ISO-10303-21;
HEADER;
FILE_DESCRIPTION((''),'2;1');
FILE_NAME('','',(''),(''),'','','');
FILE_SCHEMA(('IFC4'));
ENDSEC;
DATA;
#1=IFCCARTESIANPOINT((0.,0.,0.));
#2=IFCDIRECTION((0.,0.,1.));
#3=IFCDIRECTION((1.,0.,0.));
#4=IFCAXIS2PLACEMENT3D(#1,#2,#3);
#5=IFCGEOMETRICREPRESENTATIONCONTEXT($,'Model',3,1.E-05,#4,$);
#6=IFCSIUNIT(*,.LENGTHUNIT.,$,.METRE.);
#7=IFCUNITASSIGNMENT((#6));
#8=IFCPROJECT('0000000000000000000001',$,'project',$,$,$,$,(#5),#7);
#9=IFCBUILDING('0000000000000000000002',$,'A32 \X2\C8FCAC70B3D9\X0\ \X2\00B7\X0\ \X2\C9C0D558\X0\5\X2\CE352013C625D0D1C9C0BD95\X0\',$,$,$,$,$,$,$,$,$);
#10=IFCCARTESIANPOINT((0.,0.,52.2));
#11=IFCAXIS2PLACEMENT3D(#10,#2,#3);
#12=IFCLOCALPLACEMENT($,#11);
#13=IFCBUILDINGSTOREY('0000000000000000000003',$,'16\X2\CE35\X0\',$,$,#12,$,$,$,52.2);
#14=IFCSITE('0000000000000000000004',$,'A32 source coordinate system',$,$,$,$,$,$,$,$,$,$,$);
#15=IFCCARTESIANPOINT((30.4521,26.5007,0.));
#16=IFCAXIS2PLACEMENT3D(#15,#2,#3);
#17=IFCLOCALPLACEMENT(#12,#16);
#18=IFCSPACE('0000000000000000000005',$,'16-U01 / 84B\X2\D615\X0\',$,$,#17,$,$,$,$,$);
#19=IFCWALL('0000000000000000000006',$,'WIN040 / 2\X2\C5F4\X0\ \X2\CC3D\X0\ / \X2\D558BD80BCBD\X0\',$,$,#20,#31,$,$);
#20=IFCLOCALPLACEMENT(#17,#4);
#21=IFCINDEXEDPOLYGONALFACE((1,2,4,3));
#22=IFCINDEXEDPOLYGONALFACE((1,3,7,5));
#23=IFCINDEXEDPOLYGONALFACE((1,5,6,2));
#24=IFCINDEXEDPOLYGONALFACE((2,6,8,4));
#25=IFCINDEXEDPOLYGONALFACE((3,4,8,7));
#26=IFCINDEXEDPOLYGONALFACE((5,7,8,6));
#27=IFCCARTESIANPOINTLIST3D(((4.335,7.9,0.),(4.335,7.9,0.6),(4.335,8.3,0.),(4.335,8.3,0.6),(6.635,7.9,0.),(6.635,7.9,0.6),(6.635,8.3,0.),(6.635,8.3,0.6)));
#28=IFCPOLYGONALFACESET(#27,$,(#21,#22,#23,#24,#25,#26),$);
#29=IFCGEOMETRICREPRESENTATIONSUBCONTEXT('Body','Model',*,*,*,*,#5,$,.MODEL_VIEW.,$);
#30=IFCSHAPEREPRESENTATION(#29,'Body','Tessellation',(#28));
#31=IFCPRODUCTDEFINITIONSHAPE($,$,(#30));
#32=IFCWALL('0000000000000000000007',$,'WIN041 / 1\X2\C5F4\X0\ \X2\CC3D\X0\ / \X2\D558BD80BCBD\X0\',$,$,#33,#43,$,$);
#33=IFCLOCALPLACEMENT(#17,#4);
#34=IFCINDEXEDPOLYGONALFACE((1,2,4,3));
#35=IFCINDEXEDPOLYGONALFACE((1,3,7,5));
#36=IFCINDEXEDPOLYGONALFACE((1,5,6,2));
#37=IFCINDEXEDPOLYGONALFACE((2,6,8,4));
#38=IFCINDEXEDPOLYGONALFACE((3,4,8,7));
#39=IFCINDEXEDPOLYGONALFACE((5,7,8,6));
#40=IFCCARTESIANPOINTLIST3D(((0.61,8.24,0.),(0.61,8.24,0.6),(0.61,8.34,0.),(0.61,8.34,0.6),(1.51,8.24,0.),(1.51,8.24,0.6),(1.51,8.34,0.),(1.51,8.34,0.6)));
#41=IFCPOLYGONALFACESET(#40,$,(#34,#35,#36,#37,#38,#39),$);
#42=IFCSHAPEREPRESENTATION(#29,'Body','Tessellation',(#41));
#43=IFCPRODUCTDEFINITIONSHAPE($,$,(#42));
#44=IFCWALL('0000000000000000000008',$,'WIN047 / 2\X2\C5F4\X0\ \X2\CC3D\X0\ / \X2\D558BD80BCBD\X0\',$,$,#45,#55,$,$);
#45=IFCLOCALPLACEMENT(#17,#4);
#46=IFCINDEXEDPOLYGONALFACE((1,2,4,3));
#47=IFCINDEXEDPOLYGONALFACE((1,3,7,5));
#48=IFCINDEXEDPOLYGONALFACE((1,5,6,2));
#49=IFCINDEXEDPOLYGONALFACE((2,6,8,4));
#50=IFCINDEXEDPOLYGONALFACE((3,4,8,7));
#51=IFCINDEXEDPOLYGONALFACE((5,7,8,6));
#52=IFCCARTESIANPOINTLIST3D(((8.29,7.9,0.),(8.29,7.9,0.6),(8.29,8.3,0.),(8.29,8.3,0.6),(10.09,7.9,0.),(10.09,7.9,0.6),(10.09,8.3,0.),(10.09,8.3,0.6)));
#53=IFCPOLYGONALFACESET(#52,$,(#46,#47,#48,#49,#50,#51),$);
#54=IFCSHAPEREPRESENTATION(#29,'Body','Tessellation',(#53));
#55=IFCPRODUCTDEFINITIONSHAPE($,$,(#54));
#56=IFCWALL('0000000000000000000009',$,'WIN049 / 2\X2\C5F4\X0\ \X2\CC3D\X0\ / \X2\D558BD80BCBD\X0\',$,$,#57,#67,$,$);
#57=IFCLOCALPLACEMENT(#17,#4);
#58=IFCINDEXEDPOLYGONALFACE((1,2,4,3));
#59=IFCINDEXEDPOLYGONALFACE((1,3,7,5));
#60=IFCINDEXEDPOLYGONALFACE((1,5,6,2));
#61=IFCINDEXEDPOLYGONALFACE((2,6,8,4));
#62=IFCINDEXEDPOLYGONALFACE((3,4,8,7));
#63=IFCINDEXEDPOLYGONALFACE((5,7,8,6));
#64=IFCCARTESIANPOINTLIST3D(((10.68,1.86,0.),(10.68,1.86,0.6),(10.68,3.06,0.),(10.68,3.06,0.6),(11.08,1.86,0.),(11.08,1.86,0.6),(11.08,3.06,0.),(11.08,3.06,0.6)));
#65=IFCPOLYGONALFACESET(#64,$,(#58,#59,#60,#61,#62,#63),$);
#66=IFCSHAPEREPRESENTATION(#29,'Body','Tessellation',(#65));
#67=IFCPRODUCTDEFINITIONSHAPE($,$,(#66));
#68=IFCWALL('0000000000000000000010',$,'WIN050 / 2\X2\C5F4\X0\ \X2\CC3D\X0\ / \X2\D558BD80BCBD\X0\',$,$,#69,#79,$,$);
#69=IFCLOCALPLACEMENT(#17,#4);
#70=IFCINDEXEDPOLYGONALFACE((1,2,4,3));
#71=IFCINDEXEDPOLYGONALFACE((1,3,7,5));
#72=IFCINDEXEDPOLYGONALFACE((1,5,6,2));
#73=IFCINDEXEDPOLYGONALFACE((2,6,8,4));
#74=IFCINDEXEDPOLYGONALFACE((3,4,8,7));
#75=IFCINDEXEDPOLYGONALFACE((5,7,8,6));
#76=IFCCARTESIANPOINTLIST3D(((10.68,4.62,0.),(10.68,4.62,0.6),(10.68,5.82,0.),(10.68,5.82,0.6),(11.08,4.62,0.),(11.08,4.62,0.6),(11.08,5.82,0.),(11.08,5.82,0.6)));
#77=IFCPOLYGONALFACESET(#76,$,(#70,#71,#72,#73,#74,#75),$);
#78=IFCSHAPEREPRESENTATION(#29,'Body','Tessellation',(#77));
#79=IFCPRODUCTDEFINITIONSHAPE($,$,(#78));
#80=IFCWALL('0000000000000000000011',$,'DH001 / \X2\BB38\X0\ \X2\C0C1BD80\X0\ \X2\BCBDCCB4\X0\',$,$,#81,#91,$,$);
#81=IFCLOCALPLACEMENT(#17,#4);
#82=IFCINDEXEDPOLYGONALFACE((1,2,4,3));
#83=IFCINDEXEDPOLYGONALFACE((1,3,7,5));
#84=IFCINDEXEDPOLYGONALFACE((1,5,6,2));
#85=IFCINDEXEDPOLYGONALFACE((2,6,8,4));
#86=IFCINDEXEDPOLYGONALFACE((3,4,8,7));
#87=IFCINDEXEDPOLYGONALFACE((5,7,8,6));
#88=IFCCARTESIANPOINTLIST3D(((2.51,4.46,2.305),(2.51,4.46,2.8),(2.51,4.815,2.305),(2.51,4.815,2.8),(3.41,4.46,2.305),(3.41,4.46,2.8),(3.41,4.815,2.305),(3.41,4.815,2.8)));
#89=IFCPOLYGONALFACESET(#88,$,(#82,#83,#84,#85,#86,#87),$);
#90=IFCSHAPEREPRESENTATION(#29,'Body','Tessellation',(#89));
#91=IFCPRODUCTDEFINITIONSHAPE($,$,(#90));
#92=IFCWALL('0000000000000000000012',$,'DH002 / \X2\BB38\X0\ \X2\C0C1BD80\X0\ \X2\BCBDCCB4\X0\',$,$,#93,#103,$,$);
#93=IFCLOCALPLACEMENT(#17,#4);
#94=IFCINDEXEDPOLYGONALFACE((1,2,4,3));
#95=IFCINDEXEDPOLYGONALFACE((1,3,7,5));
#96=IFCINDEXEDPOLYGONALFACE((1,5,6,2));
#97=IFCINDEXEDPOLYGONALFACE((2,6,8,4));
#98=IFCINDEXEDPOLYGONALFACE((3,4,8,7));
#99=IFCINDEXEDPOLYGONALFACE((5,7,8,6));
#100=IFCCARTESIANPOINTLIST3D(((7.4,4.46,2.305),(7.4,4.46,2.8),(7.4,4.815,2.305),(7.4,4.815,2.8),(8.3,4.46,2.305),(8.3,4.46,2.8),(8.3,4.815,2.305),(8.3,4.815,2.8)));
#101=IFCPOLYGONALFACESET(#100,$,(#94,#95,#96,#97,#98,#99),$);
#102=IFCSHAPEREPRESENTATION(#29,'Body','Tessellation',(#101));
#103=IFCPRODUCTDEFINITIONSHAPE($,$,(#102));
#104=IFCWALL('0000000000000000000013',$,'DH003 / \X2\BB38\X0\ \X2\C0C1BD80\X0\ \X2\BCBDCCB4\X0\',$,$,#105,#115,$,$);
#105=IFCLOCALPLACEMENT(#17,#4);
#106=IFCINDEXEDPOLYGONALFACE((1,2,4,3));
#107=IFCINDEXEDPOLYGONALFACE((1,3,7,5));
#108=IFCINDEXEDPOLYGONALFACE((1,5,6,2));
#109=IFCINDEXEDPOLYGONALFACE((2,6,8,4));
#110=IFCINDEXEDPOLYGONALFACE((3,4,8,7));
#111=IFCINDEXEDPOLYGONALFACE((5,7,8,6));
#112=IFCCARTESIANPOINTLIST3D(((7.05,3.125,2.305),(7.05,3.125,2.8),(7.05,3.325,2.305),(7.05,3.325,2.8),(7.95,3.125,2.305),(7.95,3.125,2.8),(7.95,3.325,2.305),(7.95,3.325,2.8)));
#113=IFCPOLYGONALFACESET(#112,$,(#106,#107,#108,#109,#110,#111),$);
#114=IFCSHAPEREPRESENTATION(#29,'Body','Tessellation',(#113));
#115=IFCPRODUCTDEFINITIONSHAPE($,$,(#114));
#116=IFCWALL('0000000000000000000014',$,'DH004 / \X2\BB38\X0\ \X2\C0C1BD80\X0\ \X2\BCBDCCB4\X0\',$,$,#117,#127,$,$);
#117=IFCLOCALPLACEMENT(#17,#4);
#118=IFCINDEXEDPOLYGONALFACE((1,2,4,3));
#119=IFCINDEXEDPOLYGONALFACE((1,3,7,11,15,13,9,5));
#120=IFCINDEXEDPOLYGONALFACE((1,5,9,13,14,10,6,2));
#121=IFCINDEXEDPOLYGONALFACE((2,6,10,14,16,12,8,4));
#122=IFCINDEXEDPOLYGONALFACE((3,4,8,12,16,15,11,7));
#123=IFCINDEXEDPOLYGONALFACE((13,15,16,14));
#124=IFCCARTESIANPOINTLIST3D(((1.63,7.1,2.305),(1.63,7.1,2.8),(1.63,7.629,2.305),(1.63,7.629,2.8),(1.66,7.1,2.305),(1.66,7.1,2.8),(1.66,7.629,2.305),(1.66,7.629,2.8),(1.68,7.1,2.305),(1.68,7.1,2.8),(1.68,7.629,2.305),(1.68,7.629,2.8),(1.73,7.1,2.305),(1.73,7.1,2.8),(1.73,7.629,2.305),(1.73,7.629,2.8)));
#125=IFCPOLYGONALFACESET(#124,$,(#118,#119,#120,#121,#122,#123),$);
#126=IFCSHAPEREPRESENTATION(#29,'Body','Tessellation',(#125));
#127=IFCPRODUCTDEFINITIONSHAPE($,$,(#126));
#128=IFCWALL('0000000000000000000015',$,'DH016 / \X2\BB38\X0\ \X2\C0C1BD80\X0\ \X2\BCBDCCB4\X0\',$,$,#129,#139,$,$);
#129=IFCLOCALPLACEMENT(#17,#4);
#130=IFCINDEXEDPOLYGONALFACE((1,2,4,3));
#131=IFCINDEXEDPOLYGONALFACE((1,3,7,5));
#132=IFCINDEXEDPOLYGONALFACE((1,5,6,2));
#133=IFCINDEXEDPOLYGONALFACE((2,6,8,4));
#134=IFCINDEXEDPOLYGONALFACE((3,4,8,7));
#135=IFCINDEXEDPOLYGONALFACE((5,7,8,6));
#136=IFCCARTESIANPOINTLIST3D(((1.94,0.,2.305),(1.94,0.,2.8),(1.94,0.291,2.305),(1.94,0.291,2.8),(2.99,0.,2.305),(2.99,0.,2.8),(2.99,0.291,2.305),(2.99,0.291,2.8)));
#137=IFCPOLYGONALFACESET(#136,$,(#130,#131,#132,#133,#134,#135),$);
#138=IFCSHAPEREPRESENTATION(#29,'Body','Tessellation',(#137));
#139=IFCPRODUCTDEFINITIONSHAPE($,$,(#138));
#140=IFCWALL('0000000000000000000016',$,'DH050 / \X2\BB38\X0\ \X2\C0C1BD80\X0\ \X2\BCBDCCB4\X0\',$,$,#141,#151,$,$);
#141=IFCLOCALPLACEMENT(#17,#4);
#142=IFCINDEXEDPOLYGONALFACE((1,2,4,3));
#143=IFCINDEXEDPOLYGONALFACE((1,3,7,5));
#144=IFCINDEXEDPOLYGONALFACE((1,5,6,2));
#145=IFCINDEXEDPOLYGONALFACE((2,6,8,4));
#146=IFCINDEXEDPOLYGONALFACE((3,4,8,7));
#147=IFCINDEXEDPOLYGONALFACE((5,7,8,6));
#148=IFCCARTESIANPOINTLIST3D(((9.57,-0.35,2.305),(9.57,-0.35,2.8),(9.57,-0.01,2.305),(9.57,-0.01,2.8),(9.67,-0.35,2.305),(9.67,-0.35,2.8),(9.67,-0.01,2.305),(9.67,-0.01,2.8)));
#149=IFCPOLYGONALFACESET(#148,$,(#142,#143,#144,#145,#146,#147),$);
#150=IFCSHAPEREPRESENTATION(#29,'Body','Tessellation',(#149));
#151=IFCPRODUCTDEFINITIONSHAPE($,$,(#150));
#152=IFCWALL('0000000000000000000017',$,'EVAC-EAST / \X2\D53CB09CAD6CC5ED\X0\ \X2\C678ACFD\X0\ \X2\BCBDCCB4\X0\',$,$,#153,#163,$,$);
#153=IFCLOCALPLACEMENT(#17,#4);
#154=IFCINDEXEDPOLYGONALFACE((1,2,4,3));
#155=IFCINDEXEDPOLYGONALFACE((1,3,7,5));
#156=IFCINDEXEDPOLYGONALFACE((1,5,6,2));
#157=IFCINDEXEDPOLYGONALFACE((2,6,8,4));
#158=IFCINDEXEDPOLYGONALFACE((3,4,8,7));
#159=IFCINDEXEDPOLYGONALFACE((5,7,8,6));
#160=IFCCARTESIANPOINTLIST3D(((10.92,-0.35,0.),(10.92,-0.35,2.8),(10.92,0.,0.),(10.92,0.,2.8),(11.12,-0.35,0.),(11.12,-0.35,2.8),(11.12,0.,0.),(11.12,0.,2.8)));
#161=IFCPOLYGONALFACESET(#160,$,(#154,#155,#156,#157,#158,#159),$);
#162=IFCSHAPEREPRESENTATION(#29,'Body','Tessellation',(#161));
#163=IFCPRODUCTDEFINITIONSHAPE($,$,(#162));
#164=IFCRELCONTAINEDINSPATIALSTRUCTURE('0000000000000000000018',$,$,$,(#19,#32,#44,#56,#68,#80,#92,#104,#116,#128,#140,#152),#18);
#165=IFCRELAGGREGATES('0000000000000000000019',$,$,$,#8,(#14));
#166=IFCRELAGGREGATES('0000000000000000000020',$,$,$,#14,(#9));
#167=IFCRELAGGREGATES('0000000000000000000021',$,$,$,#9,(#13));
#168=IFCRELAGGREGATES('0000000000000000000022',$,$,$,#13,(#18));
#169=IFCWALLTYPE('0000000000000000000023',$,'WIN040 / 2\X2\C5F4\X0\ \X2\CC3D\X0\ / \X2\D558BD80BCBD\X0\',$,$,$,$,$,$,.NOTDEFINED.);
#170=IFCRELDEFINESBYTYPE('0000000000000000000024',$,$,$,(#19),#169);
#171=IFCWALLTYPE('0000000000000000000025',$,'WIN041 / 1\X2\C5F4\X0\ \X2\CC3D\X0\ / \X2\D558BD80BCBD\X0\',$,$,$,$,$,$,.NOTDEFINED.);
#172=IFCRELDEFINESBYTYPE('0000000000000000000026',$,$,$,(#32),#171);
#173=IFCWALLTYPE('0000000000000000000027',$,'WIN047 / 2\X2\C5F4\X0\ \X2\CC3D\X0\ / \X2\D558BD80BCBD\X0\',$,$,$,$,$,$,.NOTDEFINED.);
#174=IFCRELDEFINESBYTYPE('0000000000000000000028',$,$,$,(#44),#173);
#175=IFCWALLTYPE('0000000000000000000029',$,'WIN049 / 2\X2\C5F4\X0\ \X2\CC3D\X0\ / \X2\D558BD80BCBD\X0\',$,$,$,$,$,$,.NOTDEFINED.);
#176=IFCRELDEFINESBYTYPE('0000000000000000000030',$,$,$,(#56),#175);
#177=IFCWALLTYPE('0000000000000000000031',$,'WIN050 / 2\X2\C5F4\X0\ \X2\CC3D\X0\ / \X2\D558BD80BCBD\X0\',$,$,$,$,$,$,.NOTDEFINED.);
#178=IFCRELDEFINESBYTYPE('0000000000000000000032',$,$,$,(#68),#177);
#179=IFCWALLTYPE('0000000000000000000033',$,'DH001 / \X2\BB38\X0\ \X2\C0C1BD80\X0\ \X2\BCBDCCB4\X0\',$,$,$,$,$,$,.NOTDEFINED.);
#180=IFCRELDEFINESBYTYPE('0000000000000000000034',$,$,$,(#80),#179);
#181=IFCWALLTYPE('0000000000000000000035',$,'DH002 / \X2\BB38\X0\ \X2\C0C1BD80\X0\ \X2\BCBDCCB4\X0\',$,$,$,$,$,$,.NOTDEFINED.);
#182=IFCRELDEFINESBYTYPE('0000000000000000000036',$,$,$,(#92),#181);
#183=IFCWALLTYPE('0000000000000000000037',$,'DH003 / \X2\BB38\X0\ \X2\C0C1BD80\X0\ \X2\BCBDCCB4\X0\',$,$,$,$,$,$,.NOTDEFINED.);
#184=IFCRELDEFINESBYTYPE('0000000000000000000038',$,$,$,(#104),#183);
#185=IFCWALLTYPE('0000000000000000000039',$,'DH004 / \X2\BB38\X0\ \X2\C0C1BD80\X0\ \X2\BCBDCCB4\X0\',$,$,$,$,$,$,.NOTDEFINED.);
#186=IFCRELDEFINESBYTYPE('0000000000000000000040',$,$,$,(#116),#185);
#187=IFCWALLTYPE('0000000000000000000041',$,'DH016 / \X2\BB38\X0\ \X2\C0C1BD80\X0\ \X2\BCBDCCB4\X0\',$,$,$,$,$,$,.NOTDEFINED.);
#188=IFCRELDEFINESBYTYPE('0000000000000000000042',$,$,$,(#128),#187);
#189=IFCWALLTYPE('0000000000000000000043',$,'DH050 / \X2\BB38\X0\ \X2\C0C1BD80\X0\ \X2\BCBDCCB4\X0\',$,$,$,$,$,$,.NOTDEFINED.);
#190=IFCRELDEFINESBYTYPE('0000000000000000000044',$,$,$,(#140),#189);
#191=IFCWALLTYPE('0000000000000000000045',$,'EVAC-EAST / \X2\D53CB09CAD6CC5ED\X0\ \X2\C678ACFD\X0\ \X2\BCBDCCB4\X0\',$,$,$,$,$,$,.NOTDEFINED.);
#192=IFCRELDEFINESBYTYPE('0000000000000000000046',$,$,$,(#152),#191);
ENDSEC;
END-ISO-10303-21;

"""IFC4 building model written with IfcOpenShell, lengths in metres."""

from ifc_helpers import new_model, si_unit, frame, origin, origin_with_axes, place, context, subcontext, project, spatial, polyline, outline, extrude, source, transform, mapped, type_object, type_shapes, element, save


model = new_model("IFC4")

# Units and contexts
model_context = context("Model", 3, precision=1e-05, world=origin_with_axes())
body_context = subcontext(model_context, "Body", "Model", "MODEL_VIEW")
ifc_project = project(units=[si_unit("LENGTHUNIT", "METRE")], contexts=[model_context])

# Site, building, storey, space
site = spatial("IfcSite", under=ifc_project, Name="A32 source coordinate system")
building = spatial("IfcBuilding", under=site, Name="A32 주거동 · 지하5층–옥탑지붕")
storey_placement = place(None, frame((0.0, 0.0, 52.2), z_axis=(0.0, 0.0, 1.0), x_axis=(1.0, 0.0, 0.0)))
storey = spatial("IfcBuildingStorey", under=building, at=storey_placement, Name="16층", Elevation=52.2)
space_placement = place(storey_placement, frame((30.4521, 26.5007, 0.0), z_axis=(0.0, 0.0, 1.0), x_axis=(1.0, 0.0, 0.0)))
space = spatial("IfcSpace", under=storey, at=space_placement, Name="16-U01 / 84B형")

# Walls
wall_type_1 = type_object("IfcWallType", Name="WIN040 / 2열 창 / 하부벽", PredefinedType="NOTDEFINED")
shared_shape_1 = source(origin(), body_context, "Body", "SweptSolid", [
    extrude(outline(polyline([(4.335, 8.3), (6.635, 8.3), (6.635, 7.9), (4.335, 7.9), (4.335, 8.3)])), origin(), (0.0, 0.0, 1.0), 0.6),
])
type_shapes(wall_type_1, [shared_shape_1])
wall_1_placement = place(space_placement, origin_with_axes())
element("IfcWall", 1, at=wall_1_placement, inside=space, type_object=wall_type_1, Name="WIN040 / 2열 창 / 하부벽", context=body_context, shape_type="MappedRepresentation", body=[
    mapped(shared_shape_1, transform((0.0, 0.0, 0.0), scale=1.0)),
])
wall_type_2 = type_object("IfcWallType", Name="WIN041 / 1열 창 / 하부벽", PredefinedType="NOTDEFINED")
shared_shape_2 = source(origin(), body_context, "Body", "SweptSolid", [
    extrude(outline(polyline([(0.61, 8.34), (1.51, 8.34), (1.51, 8.24), (0.61, 8.24), (0.61, 8.34)])), origin(), (0.0, 0.0, 1.0), 0.6),
])
type_shapes(wall_type_2, [shared_shape_2])
wall_2_placement = place(space_placement, origin_with_axes())
element("IfcWall", 2, at=wall_2_placement, inside=space, type_object=wall_type_2, Name="WIN041 / 1열 창 / 하부벽", context=body_context, shape_type="MappedRepresentation", body=[
    mapped(shared_shape_2, transform((0.0, 0.0, 0.0), scale=1.0)),
])
wall_type_3 = type_object("IfcWallType", Name="WIN047 / 2열 창 / 하부벽", PredefinedType="NOTDEFINED")
shared_shape_3 = source(origin(), body_context, "Body", "SweptSolid", [
    extrude(outline(polyline([(8.29, 8.3), (10.09, 8.3), (10.09, 7.9), (8.29, 7.9), (8.29, 8.3)])), origin(), (0.0, 0.0, 1.0), 0.6),
])
type_shapes(wall_type_3, [shared_shape_3])
wall_3_placement = place(space_placement, origin_with_axes())
element("IfcWall", 3, at=wall_3_placement, inside=space, type_object=wall_type_3, Name="WIN047 / 2열 창 / 하부벽", context=body_context, shape_type="MappedRepresentation", body=[
    mapped(shared_shape_3, transform((0.0, 0.0, 0.0), scale=1.0)),
])
wall_type_4 = type_object("IfcWallType", Name="WIN049 / 2열 창 / 하부벽", PredefinedType="NOTDEFINED")
shared_shape_4 = source(origin(), body_context, "Body", "SweptSolid", [
    extrude(outline(polyline([(10.68, 3.06), (11.08, 3.06), (11.08, 1.86), (10.68, 1.86), (10.68, 3.06)])), origin(), (0.0, 0.0, 1.0), 0.6),
])
type_shapes(wall_type_4, [shared_shape_4])
wall_4_placement = place(space_placement, origin_with_axes())
element("IfcWall", 4, at=wall_4_placement, inside=space, type_object=wall_type_4, Name="WIN049 / 2열 창 / 하부벽", context=body_context, shape_type="MappedRepresentation", body=[
    mapped(shared_shape_4, transform((0.0, 0.0, 0.0), scale=1.0)),
])
wall_type_5 = type_object("IfcWallType", Name="WIN050 / 2열 창 / 하부벽", PredefinedType="NOTDEFINED")
shared_shape_5 = source(origin(), body_context, "Body", "SweptSolid", [
    extrude(outline(polyline([(10.68, 5.82), (11.08, 5.82), (11.08, 4.62), (10.68, 4.62), (10.68, 5.82)])), origin(), (0.0, 0.0, 1.0), 0.6),
])
type_shapes(wall_type_5, [shared_shape_5])
wall_5_placement = place(space_placement, origin_with_axes())
element("IfcWall", 5, at=wall_5_placement, inside=space, type_object=wall_type_5, Name="WIN050 / 2열 창 / 하부벽", context=body_context, shape_type="MappedRepresentation", body=[
    mapped(shared_shape_5, transform((0.0, 0.0, 0.0), scale=1.0)),
])
wall_type_6 = type_object("IfcWallType", Name="DH001 / 문 상부 벽체", PredefinedType="NOTDEFINED")
shared_shape_6 = source(origin(), body_context, "Body", "SweptSolid", [
    extrude(outline(polyline([(3.41, 4.815), (3.41, 4.46), (2.51, 4.46), (2.51, 4.815), (3.41, 4.815)])), frame((0.0, 0.0, 2.305)), (0.0, 0.0, 1.0), 0.495),
])
type_shapes(wall_type_6, [shared_shape_6])
wall_6_placement = place(space_placement, origin_with_axes())
element("IfcWall", 6, at=wall_6_placement, inside=space, type_object=wall_type_6, Name="DH001 / 문 상부 벽체", context=body_context, shape_type="MappedRepresentation", body=[
    mapped(shared_shape_6, transform((0.0, 0.0, 0.0), scale=1.0)),
])
wall_type_7 = type_object("IfcWallType", Name="DH002 / 문 상부 벽체", PredefinedType="NOTDEFINED")
shared_shape_7 = source(origin(), body_context, "Body", "SweptSolid", [
    extrude(outline(polyline([(8.3, 4.815), (8.3, 4.46), (7.4, 4.46), (7.4, 4.815), (8.3, 4.815)])), frame((0.0, 0.0, 2.305)), (0.0, 0.0, 1.0), 0.495),
])
type_shapes(wall_type_7, [shared_shape_7])
wall_7_placement = place(space_placement, origin_with_axes())
element("IfcWall", 7, at=wall_7_placement, inside=space, type_object=wall_type_7, Name="DH002 / 문 상부 벽체", context=body_context, shape_type="MappedRepresentation", body=[
    mapped(shared_shape_7, transform((0.0, 0.0, 0.0), scale=1.0)),
])
wall_type_8 = type_object("IfcWallType", Name="DH003 / 문 상부 벽체", PredefinedType="NOTDEFINED")
shared_shape_8 = source(origin(), body_context, "Body", "SweptSolid", [
    extrude(outline(polyline([(7.95, 3.325), (7.95, 3.125), (7.05, 3.125), (7.05, 3.325), (7.95, 3.325)])), frame((0.0, 0.0, 2.305)), (0.0, 0.0, 1.0), 0.495),
])
type_shapes(wall_type_8, [shared_shape_8])
wall_8_placement = place(space_placement, origin_with_axes())
element("IfcWall", 8, at=wall_8_placement, inside=space, type_object=wall_type_8, Name="DH003 / 문 상부 벽체", context=body_context, shape_type="MappedRepresentation", body=[
    mapped(shared_shape_8, transform((0.0, 0.0, 0.0), scale=1.0)),
])
wall_type_9 = type_object("IfcWallType", Name="DH004 / 문 상부 벽체", PredefinedType="NOTDEFINED")
shared_shape_9 = source(origin(), body_context, "Body", "SweptSolid", [
    extrude(outline(polyline([(1.66, 7.1), (1.63, 7.1), (1.63, 7.629), (1.66, 7.629), (1.68, 7.629), (1.73, 7.629), (1.73, 7.1), (1.68, 7.1), (1.66, 7.1)])), frame((0.0, 0.0, 2.305)), (0.0, 0.0, 1.0), 0.495),
])
type_shapes(wall_type_9, [shared_shape_9])
wall_9_placement = place(space_placement, origin_with_axes())
element("IfcWall", 9, at=wall_9_placement, inside=space, type_object=wall_type_9, Name="DH004 / 문 상부 벽체", context=body_context, shape_type="MappedRepresentation", body=[
    mapped(shared_shape_9, transform((0.0, 0.0, 0.0), scale=1.0)),
])
wall_type_10 = type_object("IfcWallType", Name="DH016 / 문 상부 벽체", PredefinedType="NOTDEFINED")
shared_shape_10 = source(origin(), body_context, "Body", "SweptSolid", [
    extrude(outline(polyline([(2.99, 0.291), (2.99, 0.0), (1.94, 0.0), (1.94, 0.291), (2.99, 0.291)])), frame((0.0, 0.0, 2.305)), (0.0, 0.0, 1.0), 0.495),
])
type_shapes(wall_type_10, [shared_shape_10])
wall_10_placement = place(space_placement, origin_with_axes())
element("IfcWall", 10, at=wall_10_placement, inside=space, type_object=wall_type_10, Name="DH016 / 문 상부 벽체", context=body_context, shape_type="MappedRepresentation", body=[
    mapped(shared_shape_10, transform((0.0, 0.0, 0.0), scale=1.0)),
])
wall_type_11 = type_object("IfcWallType", Name="DH050 / 문 상부 벽체", PredefinedType="NOTDEFINED")
shared_shape_11 = source(origin(), body_context, "Body", "SweptSolid", [
    extrude(outline(polyline([(9.67, -0.01), (9.67, -0.35), (9.57, -0.35), (9.57, -0.01), (9.67, -0.01)])), frame((0.0, 0.0, 2.305)), (0.0, 0.0, 1.0), 0.495),
])
type_shapes(wall_type_11, [shared_shape_11])
wall_11_placement = place(space_placement, origin_with_axes())
element("IfcWall", 11, at=wall_11_placement, inside=space, type_object=wall_type_11, Name="DH050 / 문 상부 벽체", context=body_context, shape_type="MappedRepresentation", body=[
    mapped(shared_shape_11, transform((0.0, 0.0, 0.0), scale=1.0)),
])
wall_type_12 = type_object("IfcWallType", Name="EVAC-EAST / 피난구역 외곽 벽체", PredefinedType="NOTDEFINED")
shared_shape_12 = source(origin(), body_context, "Body", "SweptSolid", [
    extrude(outline(polyline([(10.92, 0.0), (11.12, 0.0), (11.12, -0.35), (10.92, -0.35), (10.92, 0.0)])), origin(), (0.0, 0.0, 1.0), 2.8),
])
type_shapes(wall_type_12, [shared_shape_12])
wall_12_placement = place(space_placement, origin_with_axes())
element("IfcWall", 12, at=wall_12_placement, inside=space, type_object=wall_type_12, Name="EVAC-EAST / 피난구역 외곽 벽체", context=body_context, shape_type="MappedRepresentation", body=[
    mapped(shared_shape_12, transform((0.0, 0.0, 0.0), scale=1.0)),
])

save(model, "model.ifc")
